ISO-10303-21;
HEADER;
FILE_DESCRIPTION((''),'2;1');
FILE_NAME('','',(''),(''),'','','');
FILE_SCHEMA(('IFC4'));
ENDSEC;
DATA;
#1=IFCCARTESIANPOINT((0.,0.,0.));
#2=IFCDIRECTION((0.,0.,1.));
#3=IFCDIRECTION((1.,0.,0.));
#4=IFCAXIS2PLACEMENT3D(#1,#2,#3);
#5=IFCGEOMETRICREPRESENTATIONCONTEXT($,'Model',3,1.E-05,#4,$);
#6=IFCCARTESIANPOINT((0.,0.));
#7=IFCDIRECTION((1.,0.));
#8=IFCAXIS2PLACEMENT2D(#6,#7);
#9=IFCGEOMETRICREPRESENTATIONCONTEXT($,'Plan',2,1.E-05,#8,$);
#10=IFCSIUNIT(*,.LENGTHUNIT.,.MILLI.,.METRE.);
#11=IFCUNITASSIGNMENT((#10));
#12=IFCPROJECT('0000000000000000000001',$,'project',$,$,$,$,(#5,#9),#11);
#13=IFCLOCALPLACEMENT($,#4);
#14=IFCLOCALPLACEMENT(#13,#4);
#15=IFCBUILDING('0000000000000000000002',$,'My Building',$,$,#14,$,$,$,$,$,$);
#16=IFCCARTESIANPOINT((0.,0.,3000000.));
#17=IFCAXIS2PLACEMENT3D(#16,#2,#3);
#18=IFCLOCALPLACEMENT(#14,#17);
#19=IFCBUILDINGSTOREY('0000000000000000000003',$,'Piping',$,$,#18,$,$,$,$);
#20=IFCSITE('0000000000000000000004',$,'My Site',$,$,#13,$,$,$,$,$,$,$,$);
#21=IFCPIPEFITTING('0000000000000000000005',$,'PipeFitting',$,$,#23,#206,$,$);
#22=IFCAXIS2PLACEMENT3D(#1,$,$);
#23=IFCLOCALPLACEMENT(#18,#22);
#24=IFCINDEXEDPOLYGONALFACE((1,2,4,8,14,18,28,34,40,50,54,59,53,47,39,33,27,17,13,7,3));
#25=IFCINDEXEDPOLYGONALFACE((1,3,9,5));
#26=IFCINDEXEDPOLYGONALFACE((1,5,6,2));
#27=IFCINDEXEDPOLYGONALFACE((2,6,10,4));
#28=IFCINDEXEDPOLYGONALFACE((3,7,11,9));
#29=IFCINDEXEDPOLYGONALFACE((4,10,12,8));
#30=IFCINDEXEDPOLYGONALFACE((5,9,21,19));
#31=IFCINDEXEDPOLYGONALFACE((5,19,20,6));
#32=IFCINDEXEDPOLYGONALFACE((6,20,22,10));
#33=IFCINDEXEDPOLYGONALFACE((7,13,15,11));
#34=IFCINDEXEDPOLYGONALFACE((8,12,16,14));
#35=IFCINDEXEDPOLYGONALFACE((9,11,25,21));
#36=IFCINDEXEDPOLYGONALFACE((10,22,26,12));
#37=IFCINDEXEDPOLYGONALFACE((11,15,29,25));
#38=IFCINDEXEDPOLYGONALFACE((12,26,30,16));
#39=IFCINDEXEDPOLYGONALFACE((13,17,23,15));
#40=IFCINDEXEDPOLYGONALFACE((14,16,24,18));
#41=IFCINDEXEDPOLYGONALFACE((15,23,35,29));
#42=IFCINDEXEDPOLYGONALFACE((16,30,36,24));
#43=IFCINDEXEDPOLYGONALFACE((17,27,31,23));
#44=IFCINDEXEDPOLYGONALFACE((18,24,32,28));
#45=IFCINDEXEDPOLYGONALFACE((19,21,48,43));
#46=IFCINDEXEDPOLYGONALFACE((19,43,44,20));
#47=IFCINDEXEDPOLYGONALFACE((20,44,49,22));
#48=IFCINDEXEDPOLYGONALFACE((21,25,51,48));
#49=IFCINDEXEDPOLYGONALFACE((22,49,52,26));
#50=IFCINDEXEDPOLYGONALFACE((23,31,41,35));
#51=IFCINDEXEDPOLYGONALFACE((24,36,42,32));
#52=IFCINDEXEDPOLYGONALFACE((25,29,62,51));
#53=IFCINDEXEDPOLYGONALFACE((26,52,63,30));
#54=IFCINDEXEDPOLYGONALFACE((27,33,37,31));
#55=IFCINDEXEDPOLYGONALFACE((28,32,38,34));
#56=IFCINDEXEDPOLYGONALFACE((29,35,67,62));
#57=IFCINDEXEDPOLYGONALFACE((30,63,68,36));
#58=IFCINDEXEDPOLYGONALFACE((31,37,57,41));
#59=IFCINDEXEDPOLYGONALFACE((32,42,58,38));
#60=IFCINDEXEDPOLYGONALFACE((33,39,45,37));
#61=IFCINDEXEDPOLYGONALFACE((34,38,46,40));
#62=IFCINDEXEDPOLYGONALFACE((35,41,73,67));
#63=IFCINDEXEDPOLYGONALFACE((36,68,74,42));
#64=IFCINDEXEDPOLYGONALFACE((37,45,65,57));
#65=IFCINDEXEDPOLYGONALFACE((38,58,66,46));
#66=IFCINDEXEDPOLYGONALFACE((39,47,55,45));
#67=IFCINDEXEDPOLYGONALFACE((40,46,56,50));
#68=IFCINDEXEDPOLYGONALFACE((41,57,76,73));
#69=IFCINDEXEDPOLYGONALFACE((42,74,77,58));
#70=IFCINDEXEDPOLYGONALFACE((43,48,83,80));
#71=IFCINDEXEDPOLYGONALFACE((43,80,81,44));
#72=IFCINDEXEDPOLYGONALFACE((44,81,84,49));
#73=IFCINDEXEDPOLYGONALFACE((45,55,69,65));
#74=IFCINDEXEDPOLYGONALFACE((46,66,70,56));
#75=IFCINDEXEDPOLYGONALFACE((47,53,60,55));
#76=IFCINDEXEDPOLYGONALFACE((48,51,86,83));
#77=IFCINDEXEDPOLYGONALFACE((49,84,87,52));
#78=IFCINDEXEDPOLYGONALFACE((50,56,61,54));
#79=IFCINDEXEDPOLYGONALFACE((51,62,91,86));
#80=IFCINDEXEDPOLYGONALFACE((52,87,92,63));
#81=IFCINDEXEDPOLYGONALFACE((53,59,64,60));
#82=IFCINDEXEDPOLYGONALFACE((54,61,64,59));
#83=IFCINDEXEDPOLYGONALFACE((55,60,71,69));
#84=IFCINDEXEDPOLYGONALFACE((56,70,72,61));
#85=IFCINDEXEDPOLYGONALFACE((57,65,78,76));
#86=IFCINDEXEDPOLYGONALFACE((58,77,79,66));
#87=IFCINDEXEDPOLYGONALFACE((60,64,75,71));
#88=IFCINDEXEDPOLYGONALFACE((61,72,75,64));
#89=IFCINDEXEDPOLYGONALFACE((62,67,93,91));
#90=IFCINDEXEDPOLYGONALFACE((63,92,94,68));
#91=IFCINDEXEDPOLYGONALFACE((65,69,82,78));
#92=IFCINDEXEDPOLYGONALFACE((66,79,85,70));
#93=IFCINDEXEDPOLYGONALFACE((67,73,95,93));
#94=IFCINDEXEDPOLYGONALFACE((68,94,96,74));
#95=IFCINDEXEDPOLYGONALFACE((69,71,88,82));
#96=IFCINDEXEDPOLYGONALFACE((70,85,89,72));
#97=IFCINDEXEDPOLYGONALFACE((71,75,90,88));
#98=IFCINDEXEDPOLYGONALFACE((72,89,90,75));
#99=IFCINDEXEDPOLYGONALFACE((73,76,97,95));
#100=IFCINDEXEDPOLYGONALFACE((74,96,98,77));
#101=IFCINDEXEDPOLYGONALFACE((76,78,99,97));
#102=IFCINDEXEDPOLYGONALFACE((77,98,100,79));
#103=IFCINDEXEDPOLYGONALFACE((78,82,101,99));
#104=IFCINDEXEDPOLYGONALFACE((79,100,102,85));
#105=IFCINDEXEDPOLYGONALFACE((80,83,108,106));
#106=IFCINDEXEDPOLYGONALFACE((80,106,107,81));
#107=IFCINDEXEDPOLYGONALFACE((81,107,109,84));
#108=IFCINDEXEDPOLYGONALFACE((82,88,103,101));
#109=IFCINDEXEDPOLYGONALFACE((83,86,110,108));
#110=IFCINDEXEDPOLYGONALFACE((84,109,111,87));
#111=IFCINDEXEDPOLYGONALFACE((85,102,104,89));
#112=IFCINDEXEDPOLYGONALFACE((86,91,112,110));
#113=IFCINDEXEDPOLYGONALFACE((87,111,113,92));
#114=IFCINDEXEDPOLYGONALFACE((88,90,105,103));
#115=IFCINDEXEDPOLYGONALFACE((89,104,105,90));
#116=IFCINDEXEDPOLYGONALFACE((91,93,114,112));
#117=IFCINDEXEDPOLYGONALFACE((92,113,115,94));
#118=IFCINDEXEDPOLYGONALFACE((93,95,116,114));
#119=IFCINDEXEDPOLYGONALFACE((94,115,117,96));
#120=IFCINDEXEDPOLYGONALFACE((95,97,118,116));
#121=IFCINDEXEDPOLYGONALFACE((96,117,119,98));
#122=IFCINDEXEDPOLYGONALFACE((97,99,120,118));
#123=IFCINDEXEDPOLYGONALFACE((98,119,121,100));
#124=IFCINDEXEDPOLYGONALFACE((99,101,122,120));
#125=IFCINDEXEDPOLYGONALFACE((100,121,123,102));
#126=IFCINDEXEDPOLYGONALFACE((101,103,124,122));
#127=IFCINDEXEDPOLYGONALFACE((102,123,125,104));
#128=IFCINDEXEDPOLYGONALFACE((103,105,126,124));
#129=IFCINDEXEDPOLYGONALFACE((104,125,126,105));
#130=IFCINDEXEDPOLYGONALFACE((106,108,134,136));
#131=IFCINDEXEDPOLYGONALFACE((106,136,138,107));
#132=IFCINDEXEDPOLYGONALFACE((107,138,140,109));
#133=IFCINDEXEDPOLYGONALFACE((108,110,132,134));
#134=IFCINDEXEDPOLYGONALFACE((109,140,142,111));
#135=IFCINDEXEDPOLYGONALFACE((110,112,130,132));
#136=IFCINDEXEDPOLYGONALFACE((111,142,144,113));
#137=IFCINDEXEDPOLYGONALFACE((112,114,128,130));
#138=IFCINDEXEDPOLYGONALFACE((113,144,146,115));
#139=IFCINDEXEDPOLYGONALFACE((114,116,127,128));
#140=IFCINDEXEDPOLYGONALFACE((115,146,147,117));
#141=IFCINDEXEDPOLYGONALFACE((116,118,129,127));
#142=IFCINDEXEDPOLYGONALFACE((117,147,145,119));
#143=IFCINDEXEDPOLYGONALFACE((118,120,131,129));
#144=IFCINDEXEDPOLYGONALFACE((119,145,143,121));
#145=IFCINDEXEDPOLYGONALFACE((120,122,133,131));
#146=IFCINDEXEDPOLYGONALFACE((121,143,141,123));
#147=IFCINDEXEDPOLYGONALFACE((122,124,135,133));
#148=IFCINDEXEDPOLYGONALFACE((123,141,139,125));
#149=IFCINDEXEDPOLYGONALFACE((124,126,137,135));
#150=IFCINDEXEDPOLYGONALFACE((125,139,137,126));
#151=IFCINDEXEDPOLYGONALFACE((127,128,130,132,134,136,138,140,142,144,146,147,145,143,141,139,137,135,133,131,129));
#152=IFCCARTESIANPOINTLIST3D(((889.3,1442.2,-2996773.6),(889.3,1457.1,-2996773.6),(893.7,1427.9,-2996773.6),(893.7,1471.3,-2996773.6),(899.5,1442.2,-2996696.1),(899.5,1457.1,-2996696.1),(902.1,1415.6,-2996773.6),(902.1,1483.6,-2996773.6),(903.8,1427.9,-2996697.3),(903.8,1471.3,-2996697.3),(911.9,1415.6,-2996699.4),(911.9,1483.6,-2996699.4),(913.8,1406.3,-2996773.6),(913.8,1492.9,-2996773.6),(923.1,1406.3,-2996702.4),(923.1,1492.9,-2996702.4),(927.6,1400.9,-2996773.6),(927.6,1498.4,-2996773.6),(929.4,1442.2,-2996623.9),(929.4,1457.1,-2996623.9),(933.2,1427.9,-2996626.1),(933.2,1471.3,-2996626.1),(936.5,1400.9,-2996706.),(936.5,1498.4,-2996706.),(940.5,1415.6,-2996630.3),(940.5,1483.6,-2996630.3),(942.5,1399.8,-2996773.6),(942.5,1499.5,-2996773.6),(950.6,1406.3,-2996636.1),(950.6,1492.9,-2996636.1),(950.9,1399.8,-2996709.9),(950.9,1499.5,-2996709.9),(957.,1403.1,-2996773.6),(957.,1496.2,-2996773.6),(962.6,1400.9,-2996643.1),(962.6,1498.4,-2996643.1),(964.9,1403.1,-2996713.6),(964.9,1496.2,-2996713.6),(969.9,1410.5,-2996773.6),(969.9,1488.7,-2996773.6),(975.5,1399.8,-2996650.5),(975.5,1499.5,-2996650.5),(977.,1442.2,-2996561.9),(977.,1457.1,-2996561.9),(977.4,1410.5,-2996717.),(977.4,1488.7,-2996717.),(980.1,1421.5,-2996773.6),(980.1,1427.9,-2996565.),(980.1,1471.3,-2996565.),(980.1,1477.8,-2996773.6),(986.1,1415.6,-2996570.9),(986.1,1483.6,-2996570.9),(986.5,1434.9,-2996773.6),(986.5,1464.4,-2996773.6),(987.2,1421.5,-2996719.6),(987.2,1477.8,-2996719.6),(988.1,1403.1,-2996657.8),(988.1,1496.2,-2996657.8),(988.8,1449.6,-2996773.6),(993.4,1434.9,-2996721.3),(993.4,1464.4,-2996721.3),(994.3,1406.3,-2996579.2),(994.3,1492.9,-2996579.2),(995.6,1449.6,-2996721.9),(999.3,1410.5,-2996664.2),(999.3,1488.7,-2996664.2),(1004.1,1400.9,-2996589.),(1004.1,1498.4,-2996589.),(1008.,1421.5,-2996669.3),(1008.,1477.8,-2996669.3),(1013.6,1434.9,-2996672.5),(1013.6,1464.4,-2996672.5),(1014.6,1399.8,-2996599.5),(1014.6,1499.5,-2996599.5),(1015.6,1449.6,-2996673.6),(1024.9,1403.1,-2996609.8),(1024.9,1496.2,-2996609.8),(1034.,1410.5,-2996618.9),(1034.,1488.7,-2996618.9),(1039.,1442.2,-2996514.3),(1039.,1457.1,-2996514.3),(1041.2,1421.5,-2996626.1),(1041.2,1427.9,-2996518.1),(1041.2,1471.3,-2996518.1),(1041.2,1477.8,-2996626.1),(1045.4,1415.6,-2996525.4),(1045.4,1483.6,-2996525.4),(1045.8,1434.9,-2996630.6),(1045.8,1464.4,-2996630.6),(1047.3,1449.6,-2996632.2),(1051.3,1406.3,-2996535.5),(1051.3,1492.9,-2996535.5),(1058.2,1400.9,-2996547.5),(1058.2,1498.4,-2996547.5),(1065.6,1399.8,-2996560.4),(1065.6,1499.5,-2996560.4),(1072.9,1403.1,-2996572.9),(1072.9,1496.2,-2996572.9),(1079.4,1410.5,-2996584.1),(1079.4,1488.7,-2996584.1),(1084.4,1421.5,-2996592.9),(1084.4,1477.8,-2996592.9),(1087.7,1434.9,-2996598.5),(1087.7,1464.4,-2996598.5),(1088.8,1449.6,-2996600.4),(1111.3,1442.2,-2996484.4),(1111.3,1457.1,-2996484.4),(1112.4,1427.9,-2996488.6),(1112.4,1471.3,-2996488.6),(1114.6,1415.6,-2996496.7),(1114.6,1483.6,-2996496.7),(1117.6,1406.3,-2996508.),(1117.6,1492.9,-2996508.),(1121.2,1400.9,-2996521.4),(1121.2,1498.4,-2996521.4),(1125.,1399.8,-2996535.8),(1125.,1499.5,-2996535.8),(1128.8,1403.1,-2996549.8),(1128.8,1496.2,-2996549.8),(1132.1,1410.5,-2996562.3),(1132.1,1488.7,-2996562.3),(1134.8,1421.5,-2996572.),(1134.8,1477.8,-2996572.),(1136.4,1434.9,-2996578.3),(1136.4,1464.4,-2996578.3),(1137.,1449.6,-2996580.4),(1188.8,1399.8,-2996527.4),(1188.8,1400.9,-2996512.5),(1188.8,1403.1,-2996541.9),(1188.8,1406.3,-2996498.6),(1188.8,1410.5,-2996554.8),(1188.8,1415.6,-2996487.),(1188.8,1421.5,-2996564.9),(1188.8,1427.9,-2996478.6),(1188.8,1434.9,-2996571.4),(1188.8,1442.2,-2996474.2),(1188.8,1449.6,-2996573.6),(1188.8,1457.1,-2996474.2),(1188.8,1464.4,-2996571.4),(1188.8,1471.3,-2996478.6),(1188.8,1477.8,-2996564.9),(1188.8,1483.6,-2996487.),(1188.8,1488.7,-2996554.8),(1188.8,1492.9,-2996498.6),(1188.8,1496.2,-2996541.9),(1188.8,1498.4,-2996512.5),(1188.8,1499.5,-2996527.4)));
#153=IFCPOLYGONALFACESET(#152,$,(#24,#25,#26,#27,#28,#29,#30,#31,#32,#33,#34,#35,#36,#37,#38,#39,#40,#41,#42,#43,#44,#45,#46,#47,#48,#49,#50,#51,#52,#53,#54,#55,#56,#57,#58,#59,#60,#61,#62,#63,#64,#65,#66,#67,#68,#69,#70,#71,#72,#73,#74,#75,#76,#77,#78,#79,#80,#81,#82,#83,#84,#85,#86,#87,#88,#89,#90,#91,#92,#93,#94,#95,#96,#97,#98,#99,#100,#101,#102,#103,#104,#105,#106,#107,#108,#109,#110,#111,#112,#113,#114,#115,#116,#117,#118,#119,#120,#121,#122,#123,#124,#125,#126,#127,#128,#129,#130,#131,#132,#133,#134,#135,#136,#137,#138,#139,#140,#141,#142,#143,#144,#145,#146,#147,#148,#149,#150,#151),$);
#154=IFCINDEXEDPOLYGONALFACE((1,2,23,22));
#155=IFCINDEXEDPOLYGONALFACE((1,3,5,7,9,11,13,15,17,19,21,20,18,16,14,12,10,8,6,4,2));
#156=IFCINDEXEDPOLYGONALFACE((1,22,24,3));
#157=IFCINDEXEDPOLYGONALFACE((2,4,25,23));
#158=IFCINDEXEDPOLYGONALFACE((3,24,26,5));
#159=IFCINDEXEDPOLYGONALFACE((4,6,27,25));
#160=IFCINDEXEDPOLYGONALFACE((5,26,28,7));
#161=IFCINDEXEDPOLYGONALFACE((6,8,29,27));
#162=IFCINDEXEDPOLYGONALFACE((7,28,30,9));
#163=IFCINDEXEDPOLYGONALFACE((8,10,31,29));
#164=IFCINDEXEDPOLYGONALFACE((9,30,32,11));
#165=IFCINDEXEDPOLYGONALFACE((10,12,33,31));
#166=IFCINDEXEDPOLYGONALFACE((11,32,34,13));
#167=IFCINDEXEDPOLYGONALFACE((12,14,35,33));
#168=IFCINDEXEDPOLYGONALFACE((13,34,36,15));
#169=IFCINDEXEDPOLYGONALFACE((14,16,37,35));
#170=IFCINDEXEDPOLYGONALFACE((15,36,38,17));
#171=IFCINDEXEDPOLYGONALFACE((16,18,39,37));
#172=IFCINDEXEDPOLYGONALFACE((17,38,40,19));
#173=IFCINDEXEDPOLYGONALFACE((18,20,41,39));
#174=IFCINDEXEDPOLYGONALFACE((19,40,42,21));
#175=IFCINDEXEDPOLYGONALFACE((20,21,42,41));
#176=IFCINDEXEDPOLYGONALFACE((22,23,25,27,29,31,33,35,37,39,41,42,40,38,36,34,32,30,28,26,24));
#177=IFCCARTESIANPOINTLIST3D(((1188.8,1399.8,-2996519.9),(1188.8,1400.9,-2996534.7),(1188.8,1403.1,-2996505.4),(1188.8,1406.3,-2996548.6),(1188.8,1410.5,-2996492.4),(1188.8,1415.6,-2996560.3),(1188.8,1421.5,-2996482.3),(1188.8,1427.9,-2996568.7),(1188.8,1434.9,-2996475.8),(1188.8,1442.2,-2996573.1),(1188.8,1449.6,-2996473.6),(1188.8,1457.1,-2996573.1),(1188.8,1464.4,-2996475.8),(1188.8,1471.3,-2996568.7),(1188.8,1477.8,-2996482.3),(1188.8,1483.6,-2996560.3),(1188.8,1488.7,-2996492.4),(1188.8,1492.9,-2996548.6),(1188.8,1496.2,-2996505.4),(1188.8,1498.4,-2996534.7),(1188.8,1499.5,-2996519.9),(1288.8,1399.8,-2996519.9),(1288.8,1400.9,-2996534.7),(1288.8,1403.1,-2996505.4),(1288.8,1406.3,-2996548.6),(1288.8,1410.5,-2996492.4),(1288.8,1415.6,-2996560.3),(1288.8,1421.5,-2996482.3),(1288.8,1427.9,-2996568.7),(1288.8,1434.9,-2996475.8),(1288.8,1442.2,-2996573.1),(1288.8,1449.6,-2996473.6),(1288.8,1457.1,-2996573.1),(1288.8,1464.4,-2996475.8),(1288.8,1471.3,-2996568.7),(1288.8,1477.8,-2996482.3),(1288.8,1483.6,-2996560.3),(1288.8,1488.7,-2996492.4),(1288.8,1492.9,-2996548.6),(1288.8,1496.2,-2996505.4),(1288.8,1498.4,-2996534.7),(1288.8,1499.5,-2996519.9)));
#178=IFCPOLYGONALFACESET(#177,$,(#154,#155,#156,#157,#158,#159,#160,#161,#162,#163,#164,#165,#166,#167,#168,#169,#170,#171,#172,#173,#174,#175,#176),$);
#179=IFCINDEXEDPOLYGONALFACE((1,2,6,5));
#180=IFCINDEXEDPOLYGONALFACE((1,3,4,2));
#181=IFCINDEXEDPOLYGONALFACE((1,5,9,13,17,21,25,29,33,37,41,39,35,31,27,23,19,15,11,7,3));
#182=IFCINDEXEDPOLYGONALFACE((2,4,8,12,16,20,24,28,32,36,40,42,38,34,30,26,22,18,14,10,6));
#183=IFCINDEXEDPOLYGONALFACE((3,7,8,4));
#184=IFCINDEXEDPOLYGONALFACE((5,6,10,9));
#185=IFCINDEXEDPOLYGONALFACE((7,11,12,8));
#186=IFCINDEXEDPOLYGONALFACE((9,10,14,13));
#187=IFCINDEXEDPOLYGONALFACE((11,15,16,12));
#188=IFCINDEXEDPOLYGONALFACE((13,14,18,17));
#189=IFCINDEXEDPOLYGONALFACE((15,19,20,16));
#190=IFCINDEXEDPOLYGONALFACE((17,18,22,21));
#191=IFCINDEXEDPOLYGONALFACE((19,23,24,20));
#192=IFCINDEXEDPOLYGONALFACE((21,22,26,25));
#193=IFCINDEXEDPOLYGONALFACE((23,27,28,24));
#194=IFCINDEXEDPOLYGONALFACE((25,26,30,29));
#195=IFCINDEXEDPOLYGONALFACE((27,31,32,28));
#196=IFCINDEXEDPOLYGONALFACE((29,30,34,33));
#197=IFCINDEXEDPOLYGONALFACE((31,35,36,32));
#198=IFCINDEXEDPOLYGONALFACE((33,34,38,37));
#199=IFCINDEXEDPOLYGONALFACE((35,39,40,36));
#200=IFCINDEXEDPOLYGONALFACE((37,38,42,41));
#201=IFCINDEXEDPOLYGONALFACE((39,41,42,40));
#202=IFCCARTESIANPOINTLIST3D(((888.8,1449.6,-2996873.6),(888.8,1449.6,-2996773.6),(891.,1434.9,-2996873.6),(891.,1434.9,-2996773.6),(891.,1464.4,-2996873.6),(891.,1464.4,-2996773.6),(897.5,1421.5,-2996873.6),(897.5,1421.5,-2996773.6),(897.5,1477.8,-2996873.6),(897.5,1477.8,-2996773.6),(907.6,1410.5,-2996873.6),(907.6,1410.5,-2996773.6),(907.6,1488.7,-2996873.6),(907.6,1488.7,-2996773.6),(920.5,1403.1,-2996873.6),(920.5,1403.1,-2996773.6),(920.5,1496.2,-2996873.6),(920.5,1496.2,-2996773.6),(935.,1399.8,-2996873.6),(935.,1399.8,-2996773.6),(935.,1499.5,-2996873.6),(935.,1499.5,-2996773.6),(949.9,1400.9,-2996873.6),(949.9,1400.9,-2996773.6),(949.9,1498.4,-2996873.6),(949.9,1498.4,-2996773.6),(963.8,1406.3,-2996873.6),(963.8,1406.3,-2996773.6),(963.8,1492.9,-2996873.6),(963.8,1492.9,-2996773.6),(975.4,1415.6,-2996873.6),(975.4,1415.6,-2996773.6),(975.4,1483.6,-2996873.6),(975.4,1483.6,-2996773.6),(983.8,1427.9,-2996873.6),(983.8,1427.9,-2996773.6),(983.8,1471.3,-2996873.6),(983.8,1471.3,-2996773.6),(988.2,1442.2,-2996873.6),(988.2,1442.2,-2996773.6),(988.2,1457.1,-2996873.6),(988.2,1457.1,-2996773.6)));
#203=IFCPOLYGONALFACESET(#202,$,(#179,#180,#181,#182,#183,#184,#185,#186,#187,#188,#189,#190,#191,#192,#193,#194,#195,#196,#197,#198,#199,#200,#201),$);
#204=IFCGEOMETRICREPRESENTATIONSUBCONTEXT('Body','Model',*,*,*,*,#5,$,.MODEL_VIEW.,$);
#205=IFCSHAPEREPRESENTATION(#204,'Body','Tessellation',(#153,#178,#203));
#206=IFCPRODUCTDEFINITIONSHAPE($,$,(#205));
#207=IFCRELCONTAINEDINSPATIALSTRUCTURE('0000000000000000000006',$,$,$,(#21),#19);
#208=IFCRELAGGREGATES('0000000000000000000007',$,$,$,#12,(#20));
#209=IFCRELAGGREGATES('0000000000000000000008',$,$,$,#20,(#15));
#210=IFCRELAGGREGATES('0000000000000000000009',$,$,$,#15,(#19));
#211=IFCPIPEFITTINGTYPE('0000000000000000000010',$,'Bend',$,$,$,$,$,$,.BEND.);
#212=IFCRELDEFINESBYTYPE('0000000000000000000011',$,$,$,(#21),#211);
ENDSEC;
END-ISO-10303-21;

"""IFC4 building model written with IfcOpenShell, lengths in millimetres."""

from ifc_helpers import new_model, entity, si_unit, frame, origin_with_axes, origin_2d_with_axis, place, context, subcontext, project, spatial, circle, extrude, source, transform, mapped, type_object, type_shapes, element, save


model = new_model("IFC4")

# Units and contexts
model_context = context("Model", 3, precision=1e-05, world=origin_with_axes())
plan_context = context("Plan", 2, precision=1e-05, world=origin_2d_with_axis())
body_context = subcontext(model_context, "Body", "Model", "MODEL_VIEW")
ifc_project = project(units=[si_unit("LENGTHUNIT", "METRE", prefix="MILLI")], contexts=[model_context, plan_context])

# Site, building, storey
site_placement = place(None, origin_with_axes())
site = spatial("IfcSite", under=ifc_project, at=site_placement, Name="My Site")
building_placement = place(site_placement, origin_with_axes())
building = spatial("IfcBuilding", under=site, at=building_placement, Name="My Building")
storey_placement = place(building_placement, frame((0.0, 0.0, 3000000.0), z_axis=(0.0, 0.0, 1.0), x_axis=(1.0, 0.0, 0.0)))
storey = spatial("IfcBuildingStorey", under=building, at=storey_placement, Name="Piping")

# Shared definitions
pipe_fitting_type_1 = type_object("IfcPipeFittingType", Name="Bend", PredefinedType="BEND")
shared_shape_1 = source(origin_with_axes(), body_context, "Body", "SolidModel", [
    entity("IfcSweptDiskSolid", entity("IfcIndexedPolyCurve", entity("IfcCartesianPointList3D", [[0.0, 0.0, -100.0], [-73.2, 0.0, -276.8], [-250.0, 0.0, -350.0]]), [entity("IfcArcIndex", [1, 2, 3])]), 50.0),
    extrude(circle(Radius=50.0), origin_with_axes(), (0.0, 0.0, -1.0), 100.0),
    extrude(circle(Radius=50.0), frame((-250.0, 0.0, -350.0), z_axis=(-1.0, 0.0, 0.0), x_axis=(0.0, 0.0, -1.0)), (0.0, 0.0, 1.0), 100.0),
])
type_shapes(pipe_fitting_type_1, [shared_shape_1])

# Pipe fitting
for number, where, z_axis, x_axis, name in (
    (1, (1288.8, 1449.6, -2996523.6), (1.0, 0.0, 0.0), (0.0, 0.0, 1.0), "PipeFitting"),
):
    element("IfcPipeFitting", number, at=place(storey_placement, frame(where, z_axis=z_axis, x_axis=x_axis)), inside=storey, type_object=pipe_fitting_type_1, Name=name, context=body_context, shape_type="MappedRepresentation", body=[
        mapped(shared_shape_1, transform((0.0, 0.0, 0.0), x_axis=(1.0, 0.0, 0.0), y_axis=(0.0, 1.0, 0.0), z_axis=(0.0, 0.0, 1.0), scale=1.0)),
    ])

save(model, "model.ifc")
